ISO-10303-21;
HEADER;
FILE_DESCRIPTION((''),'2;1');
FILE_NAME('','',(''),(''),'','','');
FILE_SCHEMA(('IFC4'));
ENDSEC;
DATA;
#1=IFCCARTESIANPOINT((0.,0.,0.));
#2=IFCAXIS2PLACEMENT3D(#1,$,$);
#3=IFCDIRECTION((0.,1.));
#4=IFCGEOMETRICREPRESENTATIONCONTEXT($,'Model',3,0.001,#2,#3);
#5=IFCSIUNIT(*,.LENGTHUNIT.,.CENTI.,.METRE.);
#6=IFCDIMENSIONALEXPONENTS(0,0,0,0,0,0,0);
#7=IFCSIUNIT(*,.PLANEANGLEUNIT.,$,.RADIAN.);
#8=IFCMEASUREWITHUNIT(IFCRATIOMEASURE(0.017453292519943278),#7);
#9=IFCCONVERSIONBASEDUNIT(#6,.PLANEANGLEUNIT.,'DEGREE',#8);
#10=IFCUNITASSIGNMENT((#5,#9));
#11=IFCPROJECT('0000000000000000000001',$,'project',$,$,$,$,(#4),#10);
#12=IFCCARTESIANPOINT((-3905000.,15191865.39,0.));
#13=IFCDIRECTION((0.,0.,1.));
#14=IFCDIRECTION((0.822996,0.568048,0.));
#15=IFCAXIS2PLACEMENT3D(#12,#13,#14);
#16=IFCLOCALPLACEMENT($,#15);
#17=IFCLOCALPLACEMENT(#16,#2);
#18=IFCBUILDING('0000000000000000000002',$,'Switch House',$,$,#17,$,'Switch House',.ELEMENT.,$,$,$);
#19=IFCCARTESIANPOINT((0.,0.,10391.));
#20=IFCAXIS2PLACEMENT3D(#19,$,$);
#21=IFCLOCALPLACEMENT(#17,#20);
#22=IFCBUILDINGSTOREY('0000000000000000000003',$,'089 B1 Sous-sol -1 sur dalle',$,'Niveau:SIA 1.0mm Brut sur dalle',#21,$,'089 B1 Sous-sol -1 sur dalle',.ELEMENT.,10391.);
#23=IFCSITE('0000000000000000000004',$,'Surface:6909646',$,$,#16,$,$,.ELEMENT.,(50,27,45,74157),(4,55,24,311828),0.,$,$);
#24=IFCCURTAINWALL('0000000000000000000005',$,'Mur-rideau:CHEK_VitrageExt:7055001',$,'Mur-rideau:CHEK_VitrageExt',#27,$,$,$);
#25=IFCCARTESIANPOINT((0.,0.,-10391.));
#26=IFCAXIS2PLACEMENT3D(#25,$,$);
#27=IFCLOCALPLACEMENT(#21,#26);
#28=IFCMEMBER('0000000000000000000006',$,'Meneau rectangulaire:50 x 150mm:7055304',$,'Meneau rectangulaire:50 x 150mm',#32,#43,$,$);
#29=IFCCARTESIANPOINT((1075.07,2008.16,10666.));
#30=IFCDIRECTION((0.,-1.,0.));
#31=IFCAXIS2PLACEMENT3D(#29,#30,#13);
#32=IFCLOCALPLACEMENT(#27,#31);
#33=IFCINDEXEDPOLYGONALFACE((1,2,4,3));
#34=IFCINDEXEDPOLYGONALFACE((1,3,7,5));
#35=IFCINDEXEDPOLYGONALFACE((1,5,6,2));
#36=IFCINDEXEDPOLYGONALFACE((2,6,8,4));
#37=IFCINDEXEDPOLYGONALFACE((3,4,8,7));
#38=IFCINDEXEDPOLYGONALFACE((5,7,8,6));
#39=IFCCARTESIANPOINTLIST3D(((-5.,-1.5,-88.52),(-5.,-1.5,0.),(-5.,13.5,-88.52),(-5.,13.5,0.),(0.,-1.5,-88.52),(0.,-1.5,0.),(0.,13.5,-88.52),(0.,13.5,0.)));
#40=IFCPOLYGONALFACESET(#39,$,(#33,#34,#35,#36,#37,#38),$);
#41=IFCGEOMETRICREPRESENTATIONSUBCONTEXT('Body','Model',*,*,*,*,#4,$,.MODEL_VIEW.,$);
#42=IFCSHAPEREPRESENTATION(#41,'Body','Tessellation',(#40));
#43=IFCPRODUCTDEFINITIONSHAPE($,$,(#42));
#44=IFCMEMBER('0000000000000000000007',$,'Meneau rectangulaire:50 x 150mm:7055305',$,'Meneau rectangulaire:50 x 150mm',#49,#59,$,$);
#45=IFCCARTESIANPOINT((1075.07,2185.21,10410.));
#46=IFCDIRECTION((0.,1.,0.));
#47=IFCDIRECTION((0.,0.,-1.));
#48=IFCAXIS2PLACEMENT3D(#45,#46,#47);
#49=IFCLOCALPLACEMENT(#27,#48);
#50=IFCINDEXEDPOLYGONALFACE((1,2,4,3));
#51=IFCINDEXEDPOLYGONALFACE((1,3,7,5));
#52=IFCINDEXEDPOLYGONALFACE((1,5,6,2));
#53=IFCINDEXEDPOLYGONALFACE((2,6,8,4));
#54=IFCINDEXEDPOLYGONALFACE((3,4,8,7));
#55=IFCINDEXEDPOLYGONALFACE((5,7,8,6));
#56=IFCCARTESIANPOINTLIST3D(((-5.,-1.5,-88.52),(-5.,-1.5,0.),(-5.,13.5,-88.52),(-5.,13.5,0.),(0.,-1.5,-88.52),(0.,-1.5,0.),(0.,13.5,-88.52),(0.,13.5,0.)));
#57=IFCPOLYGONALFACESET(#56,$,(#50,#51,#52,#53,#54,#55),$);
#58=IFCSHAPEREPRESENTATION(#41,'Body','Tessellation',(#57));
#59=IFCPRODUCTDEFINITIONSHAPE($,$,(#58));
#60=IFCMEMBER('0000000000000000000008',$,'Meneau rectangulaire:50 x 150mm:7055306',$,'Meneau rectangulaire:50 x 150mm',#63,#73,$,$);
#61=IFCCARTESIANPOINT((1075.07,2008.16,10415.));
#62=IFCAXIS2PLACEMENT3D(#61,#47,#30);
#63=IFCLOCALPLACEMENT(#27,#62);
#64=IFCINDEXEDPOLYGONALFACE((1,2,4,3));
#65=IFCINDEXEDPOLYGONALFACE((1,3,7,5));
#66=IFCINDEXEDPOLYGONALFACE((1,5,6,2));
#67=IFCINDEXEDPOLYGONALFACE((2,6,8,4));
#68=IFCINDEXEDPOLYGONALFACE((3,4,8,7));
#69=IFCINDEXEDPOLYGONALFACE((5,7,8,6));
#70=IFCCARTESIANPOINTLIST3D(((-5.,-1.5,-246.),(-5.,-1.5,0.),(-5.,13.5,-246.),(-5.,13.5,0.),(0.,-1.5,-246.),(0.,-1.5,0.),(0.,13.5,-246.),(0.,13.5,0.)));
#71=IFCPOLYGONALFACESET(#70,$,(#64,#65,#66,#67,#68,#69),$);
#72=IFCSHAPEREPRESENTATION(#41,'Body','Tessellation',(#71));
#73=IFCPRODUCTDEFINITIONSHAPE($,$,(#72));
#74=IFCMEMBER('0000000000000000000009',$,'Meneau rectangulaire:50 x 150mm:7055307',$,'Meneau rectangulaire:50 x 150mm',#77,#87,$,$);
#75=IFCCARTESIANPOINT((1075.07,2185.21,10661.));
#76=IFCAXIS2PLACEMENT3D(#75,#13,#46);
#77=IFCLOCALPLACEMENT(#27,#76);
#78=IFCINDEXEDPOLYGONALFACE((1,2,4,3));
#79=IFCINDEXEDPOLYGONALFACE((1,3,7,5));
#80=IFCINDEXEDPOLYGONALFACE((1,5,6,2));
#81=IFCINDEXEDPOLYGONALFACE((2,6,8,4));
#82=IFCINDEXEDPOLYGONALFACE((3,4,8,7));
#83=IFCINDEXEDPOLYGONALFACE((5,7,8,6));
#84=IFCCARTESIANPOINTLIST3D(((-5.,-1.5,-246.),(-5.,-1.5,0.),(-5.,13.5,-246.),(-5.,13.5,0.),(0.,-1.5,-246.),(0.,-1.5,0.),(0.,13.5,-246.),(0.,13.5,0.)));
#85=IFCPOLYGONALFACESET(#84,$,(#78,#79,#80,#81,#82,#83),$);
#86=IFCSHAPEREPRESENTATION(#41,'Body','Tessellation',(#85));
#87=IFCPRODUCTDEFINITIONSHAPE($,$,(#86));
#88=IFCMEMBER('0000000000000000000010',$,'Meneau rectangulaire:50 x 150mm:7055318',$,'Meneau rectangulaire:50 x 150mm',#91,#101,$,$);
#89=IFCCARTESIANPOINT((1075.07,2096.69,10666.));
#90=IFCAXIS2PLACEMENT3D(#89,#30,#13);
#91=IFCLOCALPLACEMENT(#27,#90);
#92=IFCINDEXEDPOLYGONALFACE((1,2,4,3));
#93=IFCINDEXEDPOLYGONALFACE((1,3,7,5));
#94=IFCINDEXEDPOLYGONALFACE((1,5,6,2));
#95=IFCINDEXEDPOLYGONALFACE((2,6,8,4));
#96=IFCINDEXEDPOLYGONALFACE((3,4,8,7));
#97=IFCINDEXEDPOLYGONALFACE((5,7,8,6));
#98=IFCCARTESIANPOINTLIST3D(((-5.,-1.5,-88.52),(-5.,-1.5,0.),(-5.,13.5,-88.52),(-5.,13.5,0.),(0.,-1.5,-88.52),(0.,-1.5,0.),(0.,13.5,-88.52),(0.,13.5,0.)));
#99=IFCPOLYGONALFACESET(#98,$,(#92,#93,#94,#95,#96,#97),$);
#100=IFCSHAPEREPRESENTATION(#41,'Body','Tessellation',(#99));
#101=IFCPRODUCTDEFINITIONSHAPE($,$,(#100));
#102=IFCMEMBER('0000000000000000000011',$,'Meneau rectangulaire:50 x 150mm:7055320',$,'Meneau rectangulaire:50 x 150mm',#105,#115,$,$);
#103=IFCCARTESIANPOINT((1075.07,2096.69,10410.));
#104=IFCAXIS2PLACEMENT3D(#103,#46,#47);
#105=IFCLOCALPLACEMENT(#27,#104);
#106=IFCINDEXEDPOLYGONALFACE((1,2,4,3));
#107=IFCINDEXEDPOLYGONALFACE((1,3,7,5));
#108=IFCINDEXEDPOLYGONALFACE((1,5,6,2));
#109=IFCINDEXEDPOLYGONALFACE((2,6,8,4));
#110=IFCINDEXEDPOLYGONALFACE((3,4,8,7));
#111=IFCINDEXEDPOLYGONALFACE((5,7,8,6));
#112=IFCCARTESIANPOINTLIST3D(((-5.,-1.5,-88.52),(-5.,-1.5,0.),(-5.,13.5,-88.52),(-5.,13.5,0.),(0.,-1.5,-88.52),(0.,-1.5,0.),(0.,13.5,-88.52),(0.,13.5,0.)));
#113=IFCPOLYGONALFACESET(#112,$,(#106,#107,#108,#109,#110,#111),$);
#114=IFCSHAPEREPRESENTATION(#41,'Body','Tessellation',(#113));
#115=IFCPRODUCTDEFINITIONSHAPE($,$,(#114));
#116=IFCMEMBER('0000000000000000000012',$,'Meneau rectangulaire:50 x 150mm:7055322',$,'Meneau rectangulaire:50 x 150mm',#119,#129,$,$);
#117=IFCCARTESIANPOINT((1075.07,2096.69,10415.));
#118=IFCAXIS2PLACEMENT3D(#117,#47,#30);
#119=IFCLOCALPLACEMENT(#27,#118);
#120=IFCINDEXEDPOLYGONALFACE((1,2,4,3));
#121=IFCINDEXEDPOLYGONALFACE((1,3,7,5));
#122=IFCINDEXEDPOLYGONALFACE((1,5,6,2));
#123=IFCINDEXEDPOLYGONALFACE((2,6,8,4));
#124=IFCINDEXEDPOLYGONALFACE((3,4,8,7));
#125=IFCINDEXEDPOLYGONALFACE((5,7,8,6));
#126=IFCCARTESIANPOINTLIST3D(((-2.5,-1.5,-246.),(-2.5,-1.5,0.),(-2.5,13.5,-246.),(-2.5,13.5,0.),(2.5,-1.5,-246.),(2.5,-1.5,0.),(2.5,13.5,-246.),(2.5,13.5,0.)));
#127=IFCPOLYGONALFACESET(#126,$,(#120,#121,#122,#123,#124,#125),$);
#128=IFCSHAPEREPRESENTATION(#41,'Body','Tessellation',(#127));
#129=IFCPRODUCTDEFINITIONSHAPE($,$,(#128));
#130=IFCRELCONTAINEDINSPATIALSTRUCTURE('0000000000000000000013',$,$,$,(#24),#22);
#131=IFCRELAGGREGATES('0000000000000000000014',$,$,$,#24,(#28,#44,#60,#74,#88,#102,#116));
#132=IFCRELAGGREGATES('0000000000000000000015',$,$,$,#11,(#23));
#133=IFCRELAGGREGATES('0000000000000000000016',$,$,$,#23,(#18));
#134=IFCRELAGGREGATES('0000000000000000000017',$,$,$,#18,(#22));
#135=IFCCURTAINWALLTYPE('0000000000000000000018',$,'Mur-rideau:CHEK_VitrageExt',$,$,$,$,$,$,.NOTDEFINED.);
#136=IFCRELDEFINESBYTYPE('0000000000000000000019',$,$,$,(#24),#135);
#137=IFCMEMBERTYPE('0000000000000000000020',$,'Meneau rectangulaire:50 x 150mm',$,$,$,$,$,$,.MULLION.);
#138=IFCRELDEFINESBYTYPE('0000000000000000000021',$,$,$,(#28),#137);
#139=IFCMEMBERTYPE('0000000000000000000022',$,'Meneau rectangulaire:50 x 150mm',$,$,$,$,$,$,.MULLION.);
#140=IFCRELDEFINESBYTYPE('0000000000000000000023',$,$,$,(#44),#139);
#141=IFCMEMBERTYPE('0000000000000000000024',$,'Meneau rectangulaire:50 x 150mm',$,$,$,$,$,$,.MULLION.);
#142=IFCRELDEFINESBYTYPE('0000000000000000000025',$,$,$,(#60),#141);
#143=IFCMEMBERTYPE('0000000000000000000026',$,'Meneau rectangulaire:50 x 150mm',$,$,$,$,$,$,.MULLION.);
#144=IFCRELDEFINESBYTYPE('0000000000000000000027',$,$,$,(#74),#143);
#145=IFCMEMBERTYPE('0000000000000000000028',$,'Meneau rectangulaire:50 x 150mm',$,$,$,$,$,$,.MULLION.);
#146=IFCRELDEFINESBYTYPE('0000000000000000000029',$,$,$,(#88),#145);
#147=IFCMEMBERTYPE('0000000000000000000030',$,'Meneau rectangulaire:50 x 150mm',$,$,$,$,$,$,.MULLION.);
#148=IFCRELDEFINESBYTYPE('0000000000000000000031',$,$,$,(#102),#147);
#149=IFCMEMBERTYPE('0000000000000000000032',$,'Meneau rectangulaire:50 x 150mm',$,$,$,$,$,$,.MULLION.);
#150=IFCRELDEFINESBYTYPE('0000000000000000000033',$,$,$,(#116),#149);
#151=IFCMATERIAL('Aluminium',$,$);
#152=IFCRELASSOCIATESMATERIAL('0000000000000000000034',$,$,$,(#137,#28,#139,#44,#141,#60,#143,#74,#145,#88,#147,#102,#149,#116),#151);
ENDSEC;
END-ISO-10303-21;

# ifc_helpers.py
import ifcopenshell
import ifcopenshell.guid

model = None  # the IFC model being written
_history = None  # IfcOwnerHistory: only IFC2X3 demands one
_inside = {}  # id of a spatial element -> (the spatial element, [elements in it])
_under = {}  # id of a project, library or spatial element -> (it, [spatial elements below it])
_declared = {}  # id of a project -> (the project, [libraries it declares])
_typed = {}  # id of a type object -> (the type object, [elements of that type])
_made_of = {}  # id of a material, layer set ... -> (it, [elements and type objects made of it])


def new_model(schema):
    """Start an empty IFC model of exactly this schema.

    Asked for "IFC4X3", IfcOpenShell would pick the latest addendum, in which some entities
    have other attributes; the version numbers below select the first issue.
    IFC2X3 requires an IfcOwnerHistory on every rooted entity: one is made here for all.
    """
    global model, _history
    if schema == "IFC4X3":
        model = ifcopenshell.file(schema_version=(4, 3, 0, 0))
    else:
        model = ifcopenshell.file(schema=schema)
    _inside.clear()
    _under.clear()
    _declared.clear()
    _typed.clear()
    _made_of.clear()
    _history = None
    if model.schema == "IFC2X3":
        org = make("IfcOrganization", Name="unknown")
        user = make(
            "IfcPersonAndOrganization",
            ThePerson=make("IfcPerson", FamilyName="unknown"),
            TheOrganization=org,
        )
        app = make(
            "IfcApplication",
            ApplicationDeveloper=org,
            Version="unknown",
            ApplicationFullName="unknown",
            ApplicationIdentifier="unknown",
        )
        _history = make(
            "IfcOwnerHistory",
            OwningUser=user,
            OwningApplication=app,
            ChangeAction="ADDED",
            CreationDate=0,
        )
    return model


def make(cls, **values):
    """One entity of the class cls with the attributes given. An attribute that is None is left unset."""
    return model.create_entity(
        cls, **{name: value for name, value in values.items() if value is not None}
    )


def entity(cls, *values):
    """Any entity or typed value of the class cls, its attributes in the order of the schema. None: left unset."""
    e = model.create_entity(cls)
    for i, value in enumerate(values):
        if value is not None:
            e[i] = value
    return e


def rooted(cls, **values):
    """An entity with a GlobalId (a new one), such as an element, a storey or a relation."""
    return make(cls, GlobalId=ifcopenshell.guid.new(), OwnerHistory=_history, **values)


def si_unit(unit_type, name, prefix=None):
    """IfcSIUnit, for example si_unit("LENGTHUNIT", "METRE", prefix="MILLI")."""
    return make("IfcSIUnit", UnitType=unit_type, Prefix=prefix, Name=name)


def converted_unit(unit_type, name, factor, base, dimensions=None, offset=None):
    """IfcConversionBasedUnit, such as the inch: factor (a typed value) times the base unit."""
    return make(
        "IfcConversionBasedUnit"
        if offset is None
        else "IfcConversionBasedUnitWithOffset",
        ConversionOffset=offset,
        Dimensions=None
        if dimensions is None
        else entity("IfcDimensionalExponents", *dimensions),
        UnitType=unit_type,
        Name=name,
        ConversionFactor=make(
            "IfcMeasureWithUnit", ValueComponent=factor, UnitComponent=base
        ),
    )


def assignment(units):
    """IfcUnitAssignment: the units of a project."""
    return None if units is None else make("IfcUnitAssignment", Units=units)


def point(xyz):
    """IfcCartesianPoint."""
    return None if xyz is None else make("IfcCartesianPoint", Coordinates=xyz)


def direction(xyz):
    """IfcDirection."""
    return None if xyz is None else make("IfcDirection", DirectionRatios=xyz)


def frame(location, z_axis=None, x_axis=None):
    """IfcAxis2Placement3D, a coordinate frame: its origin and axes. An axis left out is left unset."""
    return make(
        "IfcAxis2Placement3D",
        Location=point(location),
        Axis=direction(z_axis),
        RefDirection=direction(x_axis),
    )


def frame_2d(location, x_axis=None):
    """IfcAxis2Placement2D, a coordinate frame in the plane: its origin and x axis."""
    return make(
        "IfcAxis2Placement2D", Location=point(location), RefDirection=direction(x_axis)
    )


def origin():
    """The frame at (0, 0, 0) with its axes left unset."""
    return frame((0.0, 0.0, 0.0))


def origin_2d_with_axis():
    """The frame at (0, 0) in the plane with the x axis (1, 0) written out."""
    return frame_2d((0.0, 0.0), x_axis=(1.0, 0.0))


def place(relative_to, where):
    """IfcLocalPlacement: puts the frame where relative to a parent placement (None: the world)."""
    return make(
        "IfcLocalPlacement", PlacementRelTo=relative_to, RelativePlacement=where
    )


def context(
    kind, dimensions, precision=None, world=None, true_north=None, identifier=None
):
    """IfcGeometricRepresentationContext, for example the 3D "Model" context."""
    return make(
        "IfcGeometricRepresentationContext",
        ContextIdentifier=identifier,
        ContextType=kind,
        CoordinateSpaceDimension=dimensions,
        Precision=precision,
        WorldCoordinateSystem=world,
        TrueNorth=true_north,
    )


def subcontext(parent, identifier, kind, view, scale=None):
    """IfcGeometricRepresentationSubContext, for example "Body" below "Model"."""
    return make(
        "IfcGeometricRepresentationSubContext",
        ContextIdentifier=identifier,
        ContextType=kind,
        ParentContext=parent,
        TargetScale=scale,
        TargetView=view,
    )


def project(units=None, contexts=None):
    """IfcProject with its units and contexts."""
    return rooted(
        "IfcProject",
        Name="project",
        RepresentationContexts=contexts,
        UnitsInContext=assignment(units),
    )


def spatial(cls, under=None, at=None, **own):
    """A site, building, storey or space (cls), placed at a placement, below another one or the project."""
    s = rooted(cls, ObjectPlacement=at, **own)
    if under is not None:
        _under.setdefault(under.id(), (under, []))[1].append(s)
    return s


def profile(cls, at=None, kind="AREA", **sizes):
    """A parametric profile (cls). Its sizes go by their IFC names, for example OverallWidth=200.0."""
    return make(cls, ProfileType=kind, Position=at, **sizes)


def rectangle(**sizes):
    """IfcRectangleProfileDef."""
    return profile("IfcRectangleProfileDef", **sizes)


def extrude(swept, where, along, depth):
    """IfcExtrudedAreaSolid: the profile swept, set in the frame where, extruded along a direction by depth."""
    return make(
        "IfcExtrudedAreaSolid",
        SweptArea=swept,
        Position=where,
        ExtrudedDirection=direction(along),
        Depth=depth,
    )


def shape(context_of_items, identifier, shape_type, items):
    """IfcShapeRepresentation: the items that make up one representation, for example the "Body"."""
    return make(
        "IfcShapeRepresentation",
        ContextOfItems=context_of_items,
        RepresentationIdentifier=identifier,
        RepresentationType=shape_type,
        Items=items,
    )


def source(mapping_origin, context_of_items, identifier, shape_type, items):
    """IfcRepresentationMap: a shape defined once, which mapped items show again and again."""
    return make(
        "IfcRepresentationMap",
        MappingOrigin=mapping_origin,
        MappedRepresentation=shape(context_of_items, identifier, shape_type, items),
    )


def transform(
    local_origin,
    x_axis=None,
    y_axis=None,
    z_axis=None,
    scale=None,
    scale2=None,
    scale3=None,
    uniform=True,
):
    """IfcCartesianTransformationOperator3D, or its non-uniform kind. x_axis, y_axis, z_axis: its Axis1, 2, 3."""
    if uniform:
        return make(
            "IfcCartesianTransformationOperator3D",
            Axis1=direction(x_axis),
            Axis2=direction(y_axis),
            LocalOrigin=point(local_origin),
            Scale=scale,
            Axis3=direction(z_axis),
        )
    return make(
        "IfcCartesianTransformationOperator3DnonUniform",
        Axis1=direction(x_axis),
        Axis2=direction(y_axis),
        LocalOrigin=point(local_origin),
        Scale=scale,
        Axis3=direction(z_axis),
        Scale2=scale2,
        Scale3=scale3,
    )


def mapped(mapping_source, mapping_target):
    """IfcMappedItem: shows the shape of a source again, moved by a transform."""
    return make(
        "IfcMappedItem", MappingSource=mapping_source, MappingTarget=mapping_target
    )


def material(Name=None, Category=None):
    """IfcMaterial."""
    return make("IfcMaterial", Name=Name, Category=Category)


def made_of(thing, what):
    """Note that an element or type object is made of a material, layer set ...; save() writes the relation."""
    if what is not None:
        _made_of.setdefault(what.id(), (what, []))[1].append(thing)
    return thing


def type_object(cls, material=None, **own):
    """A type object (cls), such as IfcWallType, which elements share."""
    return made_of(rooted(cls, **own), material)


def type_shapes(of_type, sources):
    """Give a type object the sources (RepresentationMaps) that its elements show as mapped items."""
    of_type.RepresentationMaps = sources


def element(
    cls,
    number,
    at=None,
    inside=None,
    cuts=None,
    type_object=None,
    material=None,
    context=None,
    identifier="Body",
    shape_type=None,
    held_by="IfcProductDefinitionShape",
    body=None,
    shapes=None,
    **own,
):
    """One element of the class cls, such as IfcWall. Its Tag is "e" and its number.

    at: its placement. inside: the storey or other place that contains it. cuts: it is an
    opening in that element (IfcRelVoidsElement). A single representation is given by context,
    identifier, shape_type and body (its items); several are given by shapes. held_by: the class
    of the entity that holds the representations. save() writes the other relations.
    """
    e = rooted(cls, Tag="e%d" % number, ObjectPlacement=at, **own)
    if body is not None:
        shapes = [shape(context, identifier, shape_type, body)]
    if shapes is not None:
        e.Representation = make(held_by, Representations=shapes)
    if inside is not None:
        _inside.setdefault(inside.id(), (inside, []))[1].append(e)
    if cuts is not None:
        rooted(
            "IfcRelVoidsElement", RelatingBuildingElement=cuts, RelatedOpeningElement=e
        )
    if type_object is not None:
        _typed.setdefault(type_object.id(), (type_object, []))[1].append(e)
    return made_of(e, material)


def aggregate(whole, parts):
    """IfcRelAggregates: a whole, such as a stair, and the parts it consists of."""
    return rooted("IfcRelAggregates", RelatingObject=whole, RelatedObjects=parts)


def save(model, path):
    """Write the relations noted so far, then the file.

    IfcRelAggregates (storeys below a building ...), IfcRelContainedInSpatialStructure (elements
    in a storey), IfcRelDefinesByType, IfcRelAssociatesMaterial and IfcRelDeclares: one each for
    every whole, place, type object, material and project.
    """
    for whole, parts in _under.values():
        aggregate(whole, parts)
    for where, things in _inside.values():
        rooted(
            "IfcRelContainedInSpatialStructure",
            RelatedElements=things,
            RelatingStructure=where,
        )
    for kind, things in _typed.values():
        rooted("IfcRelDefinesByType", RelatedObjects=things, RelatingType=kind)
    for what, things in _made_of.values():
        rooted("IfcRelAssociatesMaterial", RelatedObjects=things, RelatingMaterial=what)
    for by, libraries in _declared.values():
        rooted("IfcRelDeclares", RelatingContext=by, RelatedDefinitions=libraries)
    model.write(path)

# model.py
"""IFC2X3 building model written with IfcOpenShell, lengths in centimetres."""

from ifc_helpers import new_model, entity, si_unit, converted_unit, direction, frame, origin, origin_2d_with_axis, place, context, subcontext, project, spatial, rectangle, extrude, source, transform, mapped, material, type_object, type_shapes, element, aggregate, save


model = new_model("IFC2X3")

# Units and contexts
model_context = context("Model", 3, precision=0.001, world=origin(), true_north=direction((0.0, 1.0)))
body_context = subcontext(model_context, "Body", "Model", "MODEL_VIEW")
ifc_project = project(units=[si_unit("LENGTHUNIT", "METRE", prefix="CENTI"), converted_unit("PLANEANGLEUNIT", "DEGREE", entity("IfcRatioMeasure", 0.017453292519943278), si_unit("PLANEANGLEUNIT", "RADIAN"), dimensions=[0, 0, 0, 0, 0, 0, 0])], contexts=[model_context])

# Site, building, storey
site_placement = place(None, frame((-3905000.0, 15191865.39, 0.0), z_axis=(0.0, 0.0, 1.0), x_axis=(0.822996, 0.568048, 0.0)))
site = spatial("IfcSite", under=ifc_project, at=site_placement, Name="Surface:6909646", CompositionType="ELEMENT", RefLatitude=(50, 27, 45, 74157), RefLongitude=(4, 55, 24, 311828), RefElevation=0.0)
building_placement = place(site_placement, origin())
building = spatial("IfcBuilding", under=site, at=building_placement, Name="Switch House", LongName="Switch House", CompositionType="ELEMENT")
storey_placement = place(building_placement, frame((0.0, 0.0, 10391.0)))
storey = spatial("IfcBuildingStorey", under=building, at=storey_placement, Name="089 B1 Sous-sol -1 sur dalle", ObjectType="Niveau:SIA 1.0mm Brut sur dalle", LongName="089 B1 Sous-sol -1 sur dalle", CompositionType="ELEMENT", Elevation=10391.0)

# Curtain wall, members
curtain_wall_type = type_object("IfcCurtainWallType", Name="Mur-rideau:CHEK_VitrageExt", PredefinedType="NOTDEFINED")
curtain_wall_placement = place(storey_placement, frame((0.0, 0.0, -10391.0)))
curtain_wall = element("IfcCurtainWall", 1, at=curtain_wall_placement, inside=storey, type_object=curtain_wall_type, Name="Mur-rideau:CHEK_VitrageExt:7055001", ObjectType="Mur-rideau:CHEK_VitrageExt")
ifc_material_1 = material(Name="Aluminium")
member_type_1 = type_object("IfcMemberType", Name="Meneau rectangulaire:50 x 150mm", PredefinedType="MULLION", material=ifc_material_1)
shared_shape_1 = source(origin(), body_context, "Body", "SweptSolid", [
    extrude(rectangle(XDim=15.0, YDim=5.0, at=origin_2d_with_axis()), frame((-2.5, 6.0, -88.52), z_axis=(0.0, 0.0, 1.0), x_axis=(0.0, -1.0, 0.0)), (0.0, 0.0, 1.0), 88.52),
])
type_shapes(member_type_1, [shared_shape_1])
member_1_placement = place(curtain_wall_placement, frame((1075.07, 2008.16, 10666.0), z_axis=(0.0, -1.0, 0.0), x_axis=(0.0, 0.0, 1.0)))
member_1 = element("IfcMember", 2, at=member_1_placement, type_object=member_type_1, material=ifc_material_1, Name="Meneau rectangulaire:50 x 150mm:7055304", ObjectType="Meneau rectangulaire:50 x 150mm", context=body_context, shape_type="MappedRepresentation", body=[
    mapped(shared_shape_1, transform((0.0, 0.0, 0.0), scale=1.0)),
])
member_type_2 = type_object("IfcMemberType", Name="Meneau rectangulaire:50 x 150mm", PredefinedType="MULLION", material=ifc_material_1)
shared_shape_2 = source(origin(), body_context, "Body", "SweptSolid", [
    extrude(rectangle(XDim=15.0, YDim=5.0, at=origin_2d_with_axis()), frame((-2.5, 6.0, -88.52), z_axis=(0.0, 0.0, 1.0), x_axis=(0.0, -1.0, 0.0)), (0.0, 0.0, 1.0), 88.52),
])
type_shapes(member_type_2, [shared_shape_2])
member_2_placement = place(curtain_wall_placement, frame((1075.07, 2185.21, 10410.0), z_axis=(0.0, 1.0, 0.0), x_axis=(0.0, 0.0, -1.0)))
member_2 = element("IfcMember", 3, at=member_2_placement, type_object=member_type_2, material=ifc_material_1, Name="Meneau rectangulaire:50 x 150mm:7055305", ObjectType="Meneau rectangulaire:50 x 150mm", context=body_context, shape_type="MappedRepresentation", body=[
    mapped(shared_shape_2, transform((0.0, 0.0, 0.0), scale=1.0)),
])
member_type_3 = type_object("IfcMemberType", Name="Meneau rectangulaire:50 x 150mm", PredefinedType="MULLION", material=ifc_material_1)
shared_shape_3 = source(origin(), body_context, "Body", "SweptSolid", [
    extrude(rectangle(XDim=15.0, YDim=5.0, at=origin_2d_with_axis()), frame((-2.5, 6.0, -246.0), z_axis=(0.0, 0.0, 1.0), x_axis=(0.0, -1.0, 0.0)), (0.0, 0.0, 1.0), 246.0),
])
type_shapes(member_type_3, [shared_shape_3])
member_3_placement = place(curtain_wall_placement, frame((1075.07, 2008.16, 10415.0), z_axis=(0.0, 0.0, -1.0), x_axis=(0.0, -1.0, 0.0)))
member_3 = element("IfcMember", 4, at=member_3_placement, type_object=member_type_3, material=ifc_material_1, Name="Meneau rectangulaire:50 x 150mm:7055306", ObjectType="Meneau rectangulaire:50 x 150mm", context=body_context, shape_type="MappedRepresentation", body=[
    mapped(shared_shape_3, transform((0.0, 0.0, 0.0), scale=1.0)),
])
member_type_4 = type_object("IfcMemberType", Name="Meneau rectangulaire:50 x 150mm", PredefinedType="MULLION", material=ifc_material_1)
shared_shape_4 = source(origin(), body_context, "Body", "SweptSolid", [
    extrude(rectangle(XDim=15.0, YDim=5.0, at=origin_2d_with_axis()), frame((-2.5, 6.0, -246.0), z_axis=(0.0, 0.0, 1.0), x_axis=(0.0, -1.0, 0.0)), (0.0, 0.0, 1.0), 246.0),
])
type_shapes(member_type_4, [shared_shape_4])
member_4_placement = place(curtain_wall_placement, frame((1075.07, 2185.21, 10661.0), z_axis=(0.0, 0.0, 1.0), x_axis=(0.0, 1.0, 0.0)))
member_4 = element("IfcMember", 5, at=member_4_placement, type_object=member_type_4, material=ifc_material_1, Name="Meneau rectangulaire:50 x 150mm:7055307", ObjectType="Meneau rectangulaire:50 x 150mm", context=body_context, shape_type="MappedRepresentation", body=[
    mapped(shared_shape_4, transform((0.0, 0.0, 0.0), scale=1.0)),
])
member_type_5 = type_object("IfcMemberType", Name="Meneau rectangulaire:50 x 150mm", PredefinedType="MULLION", material=ifc_material_1)
shared_shape_5 = source(origin(), body_context, "Body", "SweptSolid", [
    extrude(rectangle(XDim=15.0, YDim=5.0, at=origin_2d_with_axis()), frame((-2.5, 6.0, -88.52), z_axis=(0.0, 0.0, 1.0), x_axis=(0.0, -1.0, 0.0)), (0.0, 0.0, 1.0), 88.52),
])
type_shapes(member_type_5, [shared_shape_5])
member_5_placement = place(curtain_wall_placement, frame((1075.07, 2096.69, 10666.0), z_axis=(0.0, -1.0, 0.0), x_axis=(0.0, 0.0, 1.0)))
member_5 = element("IfcMember", 6, at=member_5_placement, type_object=member_type_5, material=ifc_material_1, Name="Meneau rectangulaire:50 x 150mm:7055318", ObjectType="Meneau rectangulaire:50 x 150mm", context=body_context, shape_type="MappedRepresentation", body=[
    mapped(shared_shape_5, transform((0.0, 0.0, 0.0), scale=1.0)),
])
member_type_6 = type_object("IfcMemberType", Name="Meneau rectangulaire:50 x 150mm", PredefinedType="MULLION", material=ifc_material_1)
shared_shape_6 = source(origin(), body_context, "Body", "SweptSolid", [
    extrude(rectangle(XDim=15.0, YDim=5.0, at=origin_2d_with_axis()), frame((-2.5, 6.0, -88.52), z_axis=(0.0, 0.0, 1.0), x_axis=(0.0, -1.0, 0.0)), (0.0, 0.0, 1.0), 88.52),
])
type_shapes(member_type_6, [shared_shape_6])
member_6_placement = place(curtain_wall_placement, frame((1075.07, 2096.69, 10410.0), z_axis=(0.0, 1.0, 0.0), x_axis=(0.0, 0.0, -1.0)))
member_6 = element("IfcMember", 7, at=member_6_placement, type_object=member_type_6, material=ifc_material_1, Name="Meneau rectangulaire:50 x 150mm:7055320", ObjectType="Meneau rectangulaire:50 x 150mm", context=body_context, shape_type="MappedRepresentation", body=[
    mapped(shared_shape_6, transform((0.0, 0.0, 0.0), scale=1.0)),
])
member_type_7 = type_object("IfcMemberType", Name="Meneau rectangulaire:50 x 150mm", PredefinedType="MULLION", material=ifc_material_1)
shared_shape_7 = source(origin(), body_context, "Body", "SweptSolid", [
    extrude(rectangle(XDim=15.0, YDim=5.0, at=origin_2d_with_axis()), frame((0.0, 6.0, -246.0), z_axis=(0.0, 0.0, 1.0), x_axis=(0.0, -1.0, 0.0)), (0.0, 0.0, 1.0), 246.0),
])
type_shapes(member_type_7, [shared_shape_7])
member_7_placement = place(curtain_wall_placement, frame((1075.07, 2096.69, 10415.0), z_axis=(0.0, 0.0, -1.0), x_axis=(0.0, -1.0, 0.0)))
member_7 = element("IfcMember", 8, at=member_7_placement, type_object=member_type_7, material=ifc_material_1, Name="Meneau rectangulaire:50 x 150mm:7055322", ObjectType="Meneau rectangulaire:50 x 150mm", context=body_context, shape_type="MappedRepresentation", body=[
    mapped(shared_shape_7, transform((0.0, 0.0, 0.0), scale=1.0)),
])

aggregate(curtain_wall, [member_1, member_2, member_3, member_4, member_5, member_6, member_7])

save(model, "model.ifc")
